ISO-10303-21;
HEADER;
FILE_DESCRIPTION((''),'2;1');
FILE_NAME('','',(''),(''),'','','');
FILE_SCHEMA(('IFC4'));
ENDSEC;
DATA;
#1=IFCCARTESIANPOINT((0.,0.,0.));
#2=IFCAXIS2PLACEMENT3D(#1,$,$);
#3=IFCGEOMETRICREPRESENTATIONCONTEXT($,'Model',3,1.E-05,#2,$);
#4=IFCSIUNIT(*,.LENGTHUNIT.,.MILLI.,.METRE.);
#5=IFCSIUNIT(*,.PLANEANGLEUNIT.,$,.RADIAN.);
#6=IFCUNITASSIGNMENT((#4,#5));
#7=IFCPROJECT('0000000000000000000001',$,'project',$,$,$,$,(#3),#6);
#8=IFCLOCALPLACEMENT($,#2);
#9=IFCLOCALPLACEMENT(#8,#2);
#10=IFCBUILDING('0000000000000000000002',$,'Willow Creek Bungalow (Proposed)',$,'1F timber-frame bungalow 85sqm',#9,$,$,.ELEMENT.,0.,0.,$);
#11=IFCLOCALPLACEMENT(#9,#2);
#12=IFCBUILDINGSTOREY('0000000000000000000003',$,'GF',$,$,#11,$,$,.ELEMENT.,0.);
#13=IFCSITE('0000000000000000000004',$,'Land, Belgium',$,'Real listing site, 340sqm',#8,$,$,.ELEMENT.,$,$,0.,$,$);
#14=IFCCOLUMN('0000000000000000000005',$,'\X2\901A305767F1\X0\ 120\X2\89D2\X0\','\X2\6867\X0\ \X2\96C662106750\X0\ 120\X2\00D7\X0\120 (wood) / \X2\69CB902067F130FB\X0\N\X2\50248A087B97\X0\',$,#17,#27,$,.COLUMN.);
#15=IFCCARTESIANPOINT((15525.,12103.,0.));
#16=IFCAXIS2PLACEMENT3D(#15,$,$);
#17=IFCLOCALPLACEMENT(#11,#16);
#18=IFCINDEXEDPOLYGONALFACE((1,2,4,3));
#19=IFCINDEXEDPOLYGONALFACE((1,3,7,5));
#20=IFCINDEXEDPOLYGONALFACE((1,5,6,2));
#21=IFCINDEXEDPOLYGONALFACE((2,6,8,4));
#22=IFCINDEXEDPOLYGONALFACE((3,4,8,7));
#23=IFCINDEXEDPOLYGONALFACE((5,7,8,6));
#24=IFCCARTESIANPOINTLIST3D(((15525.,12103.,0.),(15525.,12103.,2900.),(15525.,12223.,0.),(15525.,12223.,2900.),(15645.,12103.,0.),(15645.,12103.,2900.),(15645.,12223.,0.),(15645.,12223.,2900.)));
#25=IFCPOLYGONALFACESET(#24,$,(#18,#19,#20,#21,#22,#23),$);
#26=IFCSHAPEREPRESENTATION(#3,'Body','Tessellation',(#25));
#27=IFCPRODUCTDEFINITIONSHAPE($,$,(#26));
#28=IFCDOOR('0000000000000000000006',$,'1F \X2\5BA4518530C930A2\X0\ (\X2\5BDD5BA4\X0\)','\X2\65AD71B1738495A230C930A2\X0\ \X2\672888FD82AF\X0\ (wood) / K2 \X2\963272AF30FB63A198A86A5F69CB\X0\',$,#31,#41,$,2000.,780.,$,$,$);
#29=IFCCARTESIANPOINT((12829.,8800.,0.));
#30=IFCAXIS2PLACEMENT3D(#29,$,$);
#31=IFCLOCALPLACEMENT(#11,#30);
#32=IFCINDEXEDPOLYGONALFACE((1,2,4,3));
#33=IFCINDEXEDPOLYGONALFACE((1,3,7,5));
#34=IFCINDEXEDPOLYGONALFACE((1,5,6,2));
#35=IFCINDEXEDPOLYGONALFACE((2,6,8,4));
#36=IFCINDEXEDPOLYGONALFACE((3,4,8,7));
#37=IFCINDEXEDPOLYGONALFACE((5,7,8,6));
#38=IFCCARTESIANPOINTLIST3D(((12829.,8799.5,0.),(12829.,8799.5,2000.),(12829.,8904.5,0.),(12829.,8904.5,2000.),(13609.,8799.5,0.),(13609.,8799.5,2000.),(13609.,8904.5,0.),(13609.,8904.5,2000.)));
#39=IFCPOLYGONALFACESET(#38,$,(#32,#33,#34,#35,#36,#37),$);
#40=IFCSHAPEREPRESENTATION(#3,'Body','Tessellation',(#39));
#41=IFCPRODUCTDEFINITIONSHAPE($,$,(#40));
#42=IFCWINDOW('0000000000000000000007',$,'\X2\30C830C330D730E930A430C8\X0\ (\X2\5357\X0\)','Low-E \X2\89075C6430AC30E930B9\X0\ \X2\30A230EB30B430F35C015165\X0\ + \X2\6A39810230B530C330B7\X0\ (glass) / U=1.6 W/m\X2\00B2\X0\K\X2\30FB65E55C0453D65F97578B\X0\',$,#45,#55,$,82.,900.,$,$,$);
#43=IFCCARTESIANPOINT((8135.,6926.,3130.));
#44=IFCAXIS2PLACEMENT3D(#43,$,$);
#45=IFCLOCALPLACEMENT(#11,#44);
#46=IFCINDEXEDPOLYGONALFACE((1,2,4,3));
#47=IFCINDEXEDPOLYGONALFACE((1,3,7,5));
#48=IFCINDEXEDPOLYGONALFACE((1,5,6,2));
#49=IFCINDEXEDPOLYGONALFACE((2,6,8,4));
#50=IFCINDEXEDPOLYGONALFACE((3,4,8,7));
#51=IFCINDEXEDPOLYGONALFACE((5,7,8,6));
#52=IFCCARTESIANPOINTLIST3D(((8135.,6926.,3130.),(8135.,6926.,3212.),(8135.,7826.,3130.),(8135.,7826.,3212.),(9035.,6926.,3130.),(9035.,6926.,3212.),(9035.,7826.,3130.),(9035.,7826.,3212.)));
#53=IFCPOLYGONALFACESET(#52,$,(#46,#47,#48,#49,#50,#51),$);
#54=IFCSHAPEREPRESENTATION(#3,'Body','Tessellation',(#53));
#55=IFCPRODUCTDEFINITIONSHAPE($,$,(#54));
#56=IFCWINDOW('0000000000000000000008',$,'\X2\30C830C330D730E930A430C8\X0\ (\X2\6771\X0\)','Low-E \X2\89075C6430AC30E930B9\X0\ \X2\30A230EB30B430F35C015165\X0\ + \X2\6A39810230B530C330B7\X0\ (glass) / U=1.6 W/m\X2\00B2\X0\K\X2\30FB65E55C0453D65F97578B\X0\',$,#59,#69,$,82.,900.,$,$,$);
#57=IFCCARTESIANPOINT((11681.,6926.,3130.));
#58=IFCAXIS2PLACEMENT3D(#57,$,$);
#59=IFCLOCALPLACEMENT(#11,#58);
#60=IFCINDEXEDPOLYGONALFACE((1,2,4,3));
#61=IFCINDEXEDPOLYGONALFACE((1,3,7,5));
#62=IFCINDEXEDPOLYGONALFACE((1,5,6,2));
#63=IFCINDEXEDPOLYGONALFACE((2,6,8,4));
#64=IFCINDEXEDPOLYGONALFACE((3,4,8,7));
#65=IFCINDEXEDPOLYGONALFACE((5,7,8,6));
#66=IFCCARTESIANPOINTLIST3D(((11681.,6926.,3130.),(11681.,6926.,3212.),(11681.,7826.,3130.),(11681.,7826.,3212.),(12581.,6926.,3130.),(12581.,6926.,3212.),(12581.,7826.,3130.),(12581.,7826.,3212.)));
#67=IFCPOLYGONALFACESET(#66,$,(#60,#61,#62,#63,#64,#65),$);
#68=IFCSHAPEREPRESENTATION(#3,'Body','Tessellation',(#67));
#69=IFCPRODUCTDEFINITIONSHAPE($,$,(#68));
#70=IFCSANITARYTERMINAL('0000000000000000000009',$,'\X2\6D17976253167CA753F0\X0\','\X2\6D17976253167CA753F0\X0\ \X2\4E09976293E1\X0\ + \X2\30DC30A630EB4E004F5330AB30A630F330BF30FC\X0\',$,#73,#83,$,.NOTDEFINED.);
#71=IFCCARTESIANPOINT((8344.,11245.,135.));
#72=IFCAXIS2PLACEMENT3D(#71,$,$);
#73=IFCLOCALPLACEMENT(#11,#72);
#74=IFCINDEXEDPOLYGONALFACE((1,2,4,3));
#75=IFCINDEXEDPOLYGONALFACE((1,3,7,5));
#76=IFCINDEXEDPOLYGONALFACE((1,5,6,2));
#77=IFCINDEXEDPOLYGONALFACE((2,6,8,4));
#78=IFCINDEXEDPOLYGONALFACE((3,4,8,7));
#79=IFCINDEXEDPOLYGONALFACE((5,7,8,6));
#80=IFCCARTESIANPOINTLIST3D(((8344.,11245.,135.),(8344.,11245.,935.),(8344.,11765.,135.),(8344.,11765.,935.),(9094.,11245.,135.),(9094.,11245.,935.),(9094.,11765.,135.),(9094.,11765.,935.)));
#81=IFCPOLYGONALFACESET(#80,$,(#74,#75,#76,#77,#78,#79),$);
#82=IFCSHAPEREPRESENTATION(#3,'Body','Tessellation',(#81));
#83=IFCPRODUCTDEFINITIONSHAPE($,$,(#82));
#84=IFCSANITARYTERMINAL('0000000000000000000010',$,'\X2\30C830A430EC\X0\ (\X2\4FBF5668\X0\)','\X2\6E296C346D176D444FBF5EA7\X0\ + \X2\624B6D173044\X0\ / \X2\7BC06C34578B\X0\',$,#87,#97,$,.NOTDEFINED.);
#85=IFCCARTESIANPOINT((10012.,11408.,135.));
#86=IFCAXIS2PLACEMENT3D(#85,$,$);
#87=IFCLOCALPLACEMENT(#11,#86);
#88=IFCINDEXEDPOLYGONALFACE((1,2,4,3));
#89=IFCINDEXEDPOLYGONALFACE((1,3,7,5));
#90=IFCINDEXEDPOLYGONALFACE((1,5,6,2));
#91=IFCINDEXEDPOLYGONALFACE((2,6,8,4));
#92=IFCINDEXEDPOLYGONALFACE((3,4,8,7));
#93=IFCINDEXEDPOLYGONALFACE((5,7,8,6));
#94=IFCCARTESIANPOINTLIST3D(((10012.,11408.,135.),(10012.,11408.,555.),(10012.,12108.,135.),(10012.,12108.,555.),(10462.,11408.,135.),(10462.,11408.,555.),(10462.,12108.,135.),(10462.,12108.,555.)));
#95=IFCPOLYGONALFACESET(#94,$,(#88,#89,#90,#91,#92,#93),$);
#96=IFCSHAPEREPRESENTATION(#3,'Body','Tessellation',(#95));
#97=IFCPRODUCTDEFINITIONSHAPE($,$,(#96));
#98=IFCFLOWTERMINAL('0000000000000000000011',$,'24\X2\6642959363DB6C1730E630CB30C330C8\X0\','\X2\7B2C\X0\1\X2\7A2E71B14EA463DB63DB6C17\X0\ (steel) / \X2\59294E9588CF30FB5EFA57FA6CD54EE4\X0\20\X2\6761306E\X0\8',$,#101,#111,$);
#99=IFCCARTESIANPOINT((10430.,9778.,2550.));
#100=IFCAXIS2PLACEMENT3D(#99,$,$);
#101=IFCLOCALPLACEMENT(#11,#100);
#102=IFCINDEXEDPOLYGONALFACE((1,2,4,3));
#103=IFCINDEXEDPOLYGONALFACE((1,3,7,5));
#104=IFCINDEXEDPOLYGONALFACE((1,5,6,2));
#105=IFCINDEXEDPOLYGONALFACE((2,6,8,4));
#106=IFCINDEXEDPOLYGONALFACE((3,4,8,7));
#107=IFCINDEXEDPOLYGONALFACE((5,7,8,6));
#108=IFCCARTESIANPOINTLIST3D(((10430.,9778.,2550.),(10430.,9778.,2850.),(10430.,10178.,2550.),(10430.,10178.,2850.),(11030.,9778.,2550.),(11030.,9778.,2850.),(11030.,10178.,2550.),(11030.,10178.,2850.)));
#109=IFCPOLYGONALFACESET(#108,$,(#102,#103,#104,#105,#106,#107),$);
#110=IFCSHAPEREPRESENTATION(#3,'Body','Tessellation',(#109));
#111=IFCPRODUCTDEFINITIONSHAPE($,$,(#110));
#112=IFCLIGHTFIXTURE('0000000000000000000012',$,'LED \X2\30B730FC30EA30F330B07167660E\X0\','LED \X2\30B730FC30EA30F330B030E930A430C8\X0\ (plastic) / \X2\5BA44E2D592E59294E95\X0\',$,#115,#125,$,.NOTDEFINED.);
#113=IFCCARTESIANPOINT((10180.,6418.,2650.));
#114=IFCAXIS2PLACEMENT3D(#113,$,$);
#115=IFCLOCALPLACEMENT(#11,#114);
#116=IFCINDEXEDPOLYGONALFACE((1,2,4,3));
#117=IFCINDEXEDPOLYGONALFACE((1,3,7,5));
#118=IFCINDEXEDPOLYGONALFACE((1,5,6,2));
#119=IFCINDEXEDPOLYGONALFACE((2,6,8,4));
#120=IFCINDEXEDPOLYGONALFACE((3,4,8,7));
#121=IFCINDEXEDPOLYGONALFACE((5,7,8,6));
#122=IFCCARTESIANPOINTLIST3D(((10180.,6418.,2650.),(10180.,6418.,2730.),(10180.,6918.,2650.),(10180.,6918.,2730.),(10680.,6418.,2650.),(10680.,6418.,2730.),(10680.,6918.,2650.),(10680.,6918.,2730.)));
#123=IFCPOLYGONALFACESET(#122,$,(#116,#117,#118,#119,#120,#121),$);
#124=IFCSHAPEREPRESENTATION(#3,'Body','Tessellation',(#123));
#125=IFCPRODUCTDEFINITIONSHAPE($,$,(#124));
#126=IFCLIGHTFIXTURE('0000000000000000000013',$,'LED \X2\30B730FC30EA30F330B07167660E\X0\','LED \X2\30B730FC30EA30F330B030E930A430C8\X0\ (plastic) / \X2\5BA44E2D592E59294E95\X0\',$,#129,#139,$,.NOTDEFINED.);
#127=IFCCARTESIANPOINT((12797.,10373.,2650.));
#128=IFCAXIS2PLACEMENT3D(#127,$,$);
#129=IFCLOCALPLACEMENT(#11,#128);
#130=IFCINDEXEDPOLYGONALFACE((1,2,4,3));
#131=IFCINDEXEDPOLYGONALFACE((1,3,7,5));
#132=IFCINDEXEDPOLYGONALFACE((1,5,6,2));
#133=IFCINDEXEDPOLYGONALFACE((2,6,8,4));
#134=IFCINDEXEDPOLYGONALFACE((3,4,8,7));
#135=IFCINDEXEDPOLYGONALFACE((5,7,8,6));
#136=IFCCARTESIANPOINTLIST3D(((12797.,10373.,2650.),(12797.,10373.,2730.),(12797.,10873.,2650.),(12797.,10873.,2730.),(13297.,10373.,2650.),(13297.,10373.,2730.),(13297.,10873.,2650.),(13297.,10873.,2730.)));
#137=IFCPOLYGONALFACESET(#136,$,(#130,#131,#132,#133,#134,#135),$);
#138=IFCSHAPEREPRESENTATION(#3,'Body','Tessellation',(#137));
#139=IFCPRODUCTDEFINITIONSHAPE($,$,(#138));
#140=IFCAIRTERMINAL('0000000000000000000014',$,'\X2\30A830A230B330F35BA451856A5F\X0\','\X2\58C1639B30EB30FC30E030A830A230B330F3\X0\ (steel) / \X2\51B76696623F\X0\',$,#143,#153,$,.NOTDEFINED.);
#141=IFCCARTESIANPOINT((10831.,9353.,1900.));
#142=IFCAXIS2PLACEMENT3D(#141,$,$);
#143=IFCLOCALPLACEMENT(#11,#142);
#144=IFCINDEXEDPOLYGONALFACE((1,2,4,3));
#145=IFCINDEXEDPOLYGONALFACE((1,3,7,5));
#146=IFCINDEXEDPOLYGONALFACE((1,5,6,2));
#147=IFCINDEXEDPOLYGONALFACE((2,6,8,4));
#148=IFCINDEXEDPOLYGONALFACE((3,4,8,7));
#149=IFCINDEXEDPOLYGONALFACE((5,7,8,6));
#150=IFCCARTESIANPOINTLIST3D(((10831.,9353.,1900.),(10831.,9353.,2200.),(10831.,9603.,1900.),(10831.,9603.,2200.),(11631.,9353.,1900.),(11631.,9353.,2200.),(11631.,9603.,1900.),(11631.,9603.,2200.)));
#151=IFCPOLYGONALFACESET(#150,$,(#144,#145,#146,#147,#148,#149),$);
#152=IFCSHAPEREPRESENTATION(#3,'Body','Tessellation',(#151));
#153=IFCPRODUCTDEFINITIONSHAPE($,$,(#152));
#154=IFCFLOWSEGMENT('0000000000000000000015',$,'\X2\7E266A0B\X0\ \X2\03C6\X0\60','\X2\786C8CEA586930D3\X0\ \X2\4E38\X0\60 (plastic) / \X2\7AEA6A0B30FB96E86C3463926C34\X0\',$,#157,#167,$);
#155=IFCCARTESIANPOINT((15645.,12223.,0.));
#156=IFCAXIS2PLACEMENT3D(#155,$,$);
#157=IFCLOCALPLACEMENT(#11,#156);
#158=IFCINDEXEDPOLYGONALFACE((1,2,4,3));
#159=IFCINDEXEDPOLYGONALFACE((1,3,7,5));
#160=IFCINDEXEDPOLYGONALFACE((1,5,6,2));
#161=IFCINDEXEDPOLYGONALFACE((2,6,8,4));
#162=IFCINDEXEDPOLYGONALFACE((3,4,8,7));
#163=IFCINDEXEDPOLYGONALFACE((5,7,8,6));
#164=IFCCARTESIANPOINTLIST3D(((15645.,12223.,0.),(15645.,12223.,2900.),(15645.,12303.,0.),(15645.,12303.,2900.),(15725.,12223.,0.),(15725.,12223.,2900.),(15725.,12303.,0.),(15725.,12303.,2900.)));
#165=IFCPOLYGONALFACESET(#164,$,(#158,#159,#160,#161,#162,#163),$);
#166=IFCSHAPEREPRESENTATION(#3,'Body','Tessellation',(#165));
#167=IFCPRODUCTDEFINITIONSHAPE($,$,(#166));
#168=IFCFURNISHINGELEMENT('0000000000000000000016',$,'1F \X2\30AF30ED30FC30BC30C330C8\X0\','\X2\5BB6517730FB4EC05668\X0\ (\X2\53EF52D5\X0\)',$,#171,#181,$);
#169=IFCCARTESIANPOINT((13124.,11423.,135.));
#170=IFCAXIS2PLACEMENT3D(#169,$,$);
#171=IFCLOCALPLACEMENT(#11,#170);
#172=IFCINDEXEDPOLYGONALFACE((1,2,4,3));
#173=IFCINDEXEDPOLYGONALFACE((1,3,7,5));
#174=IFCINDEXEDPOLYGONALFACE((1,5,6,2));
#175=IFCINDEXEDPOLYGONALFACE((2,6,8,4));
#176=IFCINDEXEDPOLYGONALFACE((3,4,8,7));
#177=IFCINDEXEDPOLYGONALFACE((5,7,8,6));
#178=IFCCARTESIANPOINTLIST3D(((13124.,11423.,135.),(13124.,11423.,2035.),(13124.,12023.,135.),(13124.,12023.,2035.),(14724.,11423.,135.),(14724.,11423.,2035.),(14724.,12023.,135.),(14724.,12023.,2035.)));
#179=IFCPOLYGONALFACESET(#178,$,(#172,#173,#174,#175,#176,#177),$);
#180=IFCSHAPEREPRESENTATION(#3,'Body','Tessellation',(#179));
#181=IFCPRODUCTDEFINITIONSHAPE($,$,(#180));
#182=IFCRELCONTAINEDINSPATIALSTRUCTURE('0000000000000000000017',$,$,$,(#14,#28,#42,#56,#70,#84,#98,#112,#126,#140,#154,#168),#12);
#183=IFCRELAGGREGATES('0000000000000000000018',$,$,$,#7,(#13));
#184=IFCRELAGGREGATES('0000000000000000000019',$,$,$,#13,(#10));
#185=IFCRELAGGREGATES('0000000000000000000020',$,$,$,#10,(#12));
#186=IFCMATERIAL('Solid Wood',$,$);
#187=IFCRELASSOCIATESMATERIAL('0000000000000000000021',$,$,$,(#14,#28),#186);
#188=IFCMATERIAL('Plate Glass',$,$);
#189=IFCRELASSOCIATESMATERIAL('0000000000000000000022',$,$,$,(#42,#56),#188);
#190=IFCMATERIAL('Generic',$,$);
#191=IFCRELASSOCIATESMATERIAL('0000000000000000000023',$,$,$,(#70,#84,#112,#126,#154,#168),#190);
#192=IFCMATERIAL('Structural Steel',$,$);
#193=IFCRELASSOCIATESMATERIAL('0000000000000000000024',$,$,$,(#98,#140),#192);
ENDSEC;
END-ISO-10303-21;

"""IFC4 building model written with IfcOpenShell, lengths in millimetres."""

from ifc_helpers import new_model, si_unit, frame, frame_2d, origin, place, context, project, spatial, rectangle, extrude, material, element, save


model = new_model("IFC4")

# Units and contexts
model_context = context("Model", 3, precision=1e-05, world=origin())
ifc_project = project(units=[si_unit("LENGTHUNIT", "METRE", prefix="MILLI"), si_unit("PLANEANGLEUNIT", "RADIAN")], contexts=[model_context])

# Site, building, storey
site_placement = place(None, origin())
site = spatial("IfcSite", under=ifc_project, at=site_placement, Name="Land, Belgium", ObjectType="Real listing site, 340sqm", CompositionType="ELEMENT", RefElevation=0.0)
building_placement = place(site_placement, origin())
building = spatial("IfcBuilding", under=site, at=building_placement, Name="Willow Creek Bungalow (Proposed)", ObjectType="1F timber-frame bungalow 85sqm", CompositionType="ELEMENT", ElevationOfRefHeight=0.0, ElevationOfTerrain=0.0)
storey_placement = place(building_placement, origin())
storey = spatial("IfcBuildingStorey", under=building, at=storey_placement, Name="GF", CompositionType="ELEMENT", Elevation=0.0)

# Column
ifc_material_1 = material(Name="Solid Wood")
column_1_placement = place(storey_placement, frame((15525.0, 12103.0, 0.0)))
element("IfcColumn", 1, at=column_1_placement, inside=storey, material=ifc_material_1, Name="通し柱 120角", Description="桧 集成材 120×120 (wood) / 構造柱・N値計算", PredefinedType="COLUMN", context=model_context, shape_type="SweptSolid", body=[
    extrude(rectangle(XDim=120.0, YDim=120.0, at=frame_2d((60.0, 60.0))), frame((15525.0, 12103.0, 0.0)), (0.0, 0.0, 1.0), 2900.0),
])

# Door
door_placement = place(storey_placement, frame((12829.0, 8800.0, 0.0)))
element("IfcDoor", 2, at=door_placement, inside=storey, material=ifc_material_1, Name="1F 室内ドア (寝室)", Description="断熱玄関ドア 木製芯 (wood) / K2 防犯・採風機構", OverallHeight=2000.0, OverallWidth=780.0, context=model_context, shape_type="SweptSolid", body=[
    extrude(rectangle(XDim=780.0, YDim=105.0, at=frame_2d((390.0, 52.0))), frame((12829.0, 8800.0, 0.0)), (0.0, 0.0, 1.0), 2000.0),
])

# Windows
ifc_material_2 = material(Name="Plate Glass")
window_1_placement = place(storey_placement, frame((8135.0, 6926.0, 3130.0)))
element("IfcWindow", 3, at=window_1_placement, inside=storey, material=ifc_material_2, Name="トップライト (南)", Description="Low-E 複層ガラス アルゴン封入 + 樹脂サッシ (glass) / U=1.6 W/m²K・日射取得型", OverallHeight=82.0, OverallWidth=900.0, context=model_context, shape_type="SweptSolid", body=[
    extrude(rectangle(XDim=900.0, YDim=900.0, at=frame_2d((450.0, 450.0))), frame((8135.0, 6926.0, 3130.0)), (0.0, 0.0, 1.0), 82.0),
])
window_2_placement = place(storey_placement, frame((11681.0, 6926.0, 3130.0)))
element("IfcWindow", 4, at=window_2_placement, inside=storey, material=ifc_material_2, Name="トップライト (東)", Description="Low-E 複層ガラス アルゴン封入 + 樹脂サッシ (glass) / U=1.6 W/m²K・日射取得型", OverallHeight=82.0, OverallWidth=900.0, context=model_context, shape_type="SweptSolid", body=[
    extrude(rectangle(XDim=900.0, YDim=900.0, at=frame_2d((450.0, 450.0))), frame((11681.0, 6926.0, 3130.0)), (0.0, 0.0, 1.0), 82.0),
])

# Sanitary terminals
ifc_material_3 = material(Name="Generic")
sanitary_terminal_1_placement = place(storey_placement, frame((8344.0, 11245.0, 135.0)))
element("IfcSanitaryTerminal", 5, at=sanitary_terminal_1_placement, inside=storey, material=ifc_material_3, Name="洗面化粧台", Description="洗面化粧台 三面鏡 + ボウル一体カウンター", PredefinedType="NOTDEFINED", context=model_context, shape_type="SweptSolid", body=[
    extrude(rectangle(XDim=750.0, YDim=520.0, at=frame_2d((375.0, 260.0))), frame((8344.0, 11245.0, 135.0)), (0.0, 0.0, 1.0), 800.0),
])
sanitary_terminal_2_placement = place(storey_placement, frame((10012.0, 11408.0, 135.0)))
element("IfcSanitaryTerminal", 6, at=sanitary_terminal_2_placement, inside=storey, material=ifc_material_3, Name="トイレ (便器)", Description="温水洗浄便座 + 手洗い / 節水型", PredefinedType="NOTDEFINED", context=model_context, shape_type="SweptSolid", body=[
    extrude(rectangle(XDim=450.0, YDim=700.0, at=frame_2d((225.0, 350.0))), frame((10012.0, 11408.0, 135.0)), (0.0, 0.0, 1.0), 420.0),
])

# Flow terminal
ifc_material_4 = material(Name="Structural Steel")
flow_terminal_placement = place(storey_placement, frame((10430.0, 9778.0, 2550.0)))
element("IfcFlowTerminal", 7, at=flow_terminal_placement, inside=storey, material=ifc_material_4, Name="24時間換気ユニット", Description="第1種熱交換換気 (steel) / 天井裏・建基法令20条の8", context=model_context, shape_type="SweptSolid", body=[
    extrude(rectangle(XDim=600.0, YDim=400.0, at=frame_2d((300.0, 200.0))), frame((10430.0, 9778.0, 2550.0)), (0.0, 0.0, 1.0), 300.0),
])

# Light fixtures
light_fixture_1_placement = place(storey_placement, frame((10180.0, 6418.0, 2650.0)))
element("IfcLightFixture", 8, at=light_fixture_1_placement, inside=storey, material=ifc_material_3, Name="LED シーリング照明", Description="LED シーリングライト (plastic) / 室中央天井", PredefinedType="NOTDEFINED", context=model_context, shape_type="SweptSolid", body=[
    extrude(rectangle(XDim=500.0, YDim=500.0, at=frame_2d((250.0, 250.0))), frame((10180.0, 6418.0, 2650.0)), (0.0, 0.0, 1.0), 80.0),
])
light_fixture_2_placement = place(storey_placement, frame((12797.0, 10373.0, 2650.0)))
element("IfcLightFixture", 9, at=light_fixture_2_placement, inside=storey, material=ifc_material_3, Name="LED シーリング照明", Description="LED シーリングライト (plastic) / 室中央天井", PredefinedType="NOTDEFINED", context=model_context, shape_type="SweptSolid", body=[
    extrude(rectangle(XDim=500.0, YDim=500.0, at=frame_2d((250.0, 250.0))), frame((12797.0, 10373.0, 2650.0)), (0.0, 0.0, 1.0), 80.0),
])

# Air terminal
air_terminal_placement = place(storey_placement, frame((10831.0, 9353.0, 1900.0)))
element("IfcAirTerminal", 10, at=air_terminal_placement, inside=storey, material=ifc_material_4, Name="エアコン室内機", Description="壁掛ルームエアコン (steel) / 冷暖房", PredefinedType="NOTDEFINED", context=model_context, shape_type="SweptSolid", body=[
    extrude(rectangle(XDim=800.0, YDim=250.0, at=frame_2d((400.0, 125.0))), frame((10831.0, 9353.0, 1900.0)), (0.0, 0.0, 1.0), 300.0),
])

# Flow segment
flow_segment_placement = place(storey_placement, frame((15645.0, 12223.0, 0.0)))
element("IfcFlowSegment", 11, at=flow_segment_placement, inside=storey, material=ifc_material_3, Name="縦樋 φ60", Description="硬質塩ビ 丸60 (plastic) / 竪樋・雨水排水", context=model_context, shape_type="SweptSolid", body=[
    extrude(rectangle(XDim=80.0, YDim=80.0, at=frame_2d((40.0, 40.0))), frame((15645.0, 12223.0, 0.0)), (0.0, 0.0, 1.0), 2900.0),
])

# Furnishing element
furnishing_placement = place(storey_placement, frame((13124.0, 11423.0, 135.0)))
element("IfcFurnishingElement", 12, at=furnishing_placement, inside=storey, material=ifc_material_3, Name="1F クローゼット", Description="家具・什器 (可動)", context=model_context, shape_type="SweptSolid", body=[
    extrude(rectangle(XDim=1600.0, YDim=600.0, at=frame_2d((800.0, 300.0))), frame((13124.0, 11423.0, 135.0)), (0.0, 0.0, 1.0), 1900.0),
])

save(model, "model.ifc")
